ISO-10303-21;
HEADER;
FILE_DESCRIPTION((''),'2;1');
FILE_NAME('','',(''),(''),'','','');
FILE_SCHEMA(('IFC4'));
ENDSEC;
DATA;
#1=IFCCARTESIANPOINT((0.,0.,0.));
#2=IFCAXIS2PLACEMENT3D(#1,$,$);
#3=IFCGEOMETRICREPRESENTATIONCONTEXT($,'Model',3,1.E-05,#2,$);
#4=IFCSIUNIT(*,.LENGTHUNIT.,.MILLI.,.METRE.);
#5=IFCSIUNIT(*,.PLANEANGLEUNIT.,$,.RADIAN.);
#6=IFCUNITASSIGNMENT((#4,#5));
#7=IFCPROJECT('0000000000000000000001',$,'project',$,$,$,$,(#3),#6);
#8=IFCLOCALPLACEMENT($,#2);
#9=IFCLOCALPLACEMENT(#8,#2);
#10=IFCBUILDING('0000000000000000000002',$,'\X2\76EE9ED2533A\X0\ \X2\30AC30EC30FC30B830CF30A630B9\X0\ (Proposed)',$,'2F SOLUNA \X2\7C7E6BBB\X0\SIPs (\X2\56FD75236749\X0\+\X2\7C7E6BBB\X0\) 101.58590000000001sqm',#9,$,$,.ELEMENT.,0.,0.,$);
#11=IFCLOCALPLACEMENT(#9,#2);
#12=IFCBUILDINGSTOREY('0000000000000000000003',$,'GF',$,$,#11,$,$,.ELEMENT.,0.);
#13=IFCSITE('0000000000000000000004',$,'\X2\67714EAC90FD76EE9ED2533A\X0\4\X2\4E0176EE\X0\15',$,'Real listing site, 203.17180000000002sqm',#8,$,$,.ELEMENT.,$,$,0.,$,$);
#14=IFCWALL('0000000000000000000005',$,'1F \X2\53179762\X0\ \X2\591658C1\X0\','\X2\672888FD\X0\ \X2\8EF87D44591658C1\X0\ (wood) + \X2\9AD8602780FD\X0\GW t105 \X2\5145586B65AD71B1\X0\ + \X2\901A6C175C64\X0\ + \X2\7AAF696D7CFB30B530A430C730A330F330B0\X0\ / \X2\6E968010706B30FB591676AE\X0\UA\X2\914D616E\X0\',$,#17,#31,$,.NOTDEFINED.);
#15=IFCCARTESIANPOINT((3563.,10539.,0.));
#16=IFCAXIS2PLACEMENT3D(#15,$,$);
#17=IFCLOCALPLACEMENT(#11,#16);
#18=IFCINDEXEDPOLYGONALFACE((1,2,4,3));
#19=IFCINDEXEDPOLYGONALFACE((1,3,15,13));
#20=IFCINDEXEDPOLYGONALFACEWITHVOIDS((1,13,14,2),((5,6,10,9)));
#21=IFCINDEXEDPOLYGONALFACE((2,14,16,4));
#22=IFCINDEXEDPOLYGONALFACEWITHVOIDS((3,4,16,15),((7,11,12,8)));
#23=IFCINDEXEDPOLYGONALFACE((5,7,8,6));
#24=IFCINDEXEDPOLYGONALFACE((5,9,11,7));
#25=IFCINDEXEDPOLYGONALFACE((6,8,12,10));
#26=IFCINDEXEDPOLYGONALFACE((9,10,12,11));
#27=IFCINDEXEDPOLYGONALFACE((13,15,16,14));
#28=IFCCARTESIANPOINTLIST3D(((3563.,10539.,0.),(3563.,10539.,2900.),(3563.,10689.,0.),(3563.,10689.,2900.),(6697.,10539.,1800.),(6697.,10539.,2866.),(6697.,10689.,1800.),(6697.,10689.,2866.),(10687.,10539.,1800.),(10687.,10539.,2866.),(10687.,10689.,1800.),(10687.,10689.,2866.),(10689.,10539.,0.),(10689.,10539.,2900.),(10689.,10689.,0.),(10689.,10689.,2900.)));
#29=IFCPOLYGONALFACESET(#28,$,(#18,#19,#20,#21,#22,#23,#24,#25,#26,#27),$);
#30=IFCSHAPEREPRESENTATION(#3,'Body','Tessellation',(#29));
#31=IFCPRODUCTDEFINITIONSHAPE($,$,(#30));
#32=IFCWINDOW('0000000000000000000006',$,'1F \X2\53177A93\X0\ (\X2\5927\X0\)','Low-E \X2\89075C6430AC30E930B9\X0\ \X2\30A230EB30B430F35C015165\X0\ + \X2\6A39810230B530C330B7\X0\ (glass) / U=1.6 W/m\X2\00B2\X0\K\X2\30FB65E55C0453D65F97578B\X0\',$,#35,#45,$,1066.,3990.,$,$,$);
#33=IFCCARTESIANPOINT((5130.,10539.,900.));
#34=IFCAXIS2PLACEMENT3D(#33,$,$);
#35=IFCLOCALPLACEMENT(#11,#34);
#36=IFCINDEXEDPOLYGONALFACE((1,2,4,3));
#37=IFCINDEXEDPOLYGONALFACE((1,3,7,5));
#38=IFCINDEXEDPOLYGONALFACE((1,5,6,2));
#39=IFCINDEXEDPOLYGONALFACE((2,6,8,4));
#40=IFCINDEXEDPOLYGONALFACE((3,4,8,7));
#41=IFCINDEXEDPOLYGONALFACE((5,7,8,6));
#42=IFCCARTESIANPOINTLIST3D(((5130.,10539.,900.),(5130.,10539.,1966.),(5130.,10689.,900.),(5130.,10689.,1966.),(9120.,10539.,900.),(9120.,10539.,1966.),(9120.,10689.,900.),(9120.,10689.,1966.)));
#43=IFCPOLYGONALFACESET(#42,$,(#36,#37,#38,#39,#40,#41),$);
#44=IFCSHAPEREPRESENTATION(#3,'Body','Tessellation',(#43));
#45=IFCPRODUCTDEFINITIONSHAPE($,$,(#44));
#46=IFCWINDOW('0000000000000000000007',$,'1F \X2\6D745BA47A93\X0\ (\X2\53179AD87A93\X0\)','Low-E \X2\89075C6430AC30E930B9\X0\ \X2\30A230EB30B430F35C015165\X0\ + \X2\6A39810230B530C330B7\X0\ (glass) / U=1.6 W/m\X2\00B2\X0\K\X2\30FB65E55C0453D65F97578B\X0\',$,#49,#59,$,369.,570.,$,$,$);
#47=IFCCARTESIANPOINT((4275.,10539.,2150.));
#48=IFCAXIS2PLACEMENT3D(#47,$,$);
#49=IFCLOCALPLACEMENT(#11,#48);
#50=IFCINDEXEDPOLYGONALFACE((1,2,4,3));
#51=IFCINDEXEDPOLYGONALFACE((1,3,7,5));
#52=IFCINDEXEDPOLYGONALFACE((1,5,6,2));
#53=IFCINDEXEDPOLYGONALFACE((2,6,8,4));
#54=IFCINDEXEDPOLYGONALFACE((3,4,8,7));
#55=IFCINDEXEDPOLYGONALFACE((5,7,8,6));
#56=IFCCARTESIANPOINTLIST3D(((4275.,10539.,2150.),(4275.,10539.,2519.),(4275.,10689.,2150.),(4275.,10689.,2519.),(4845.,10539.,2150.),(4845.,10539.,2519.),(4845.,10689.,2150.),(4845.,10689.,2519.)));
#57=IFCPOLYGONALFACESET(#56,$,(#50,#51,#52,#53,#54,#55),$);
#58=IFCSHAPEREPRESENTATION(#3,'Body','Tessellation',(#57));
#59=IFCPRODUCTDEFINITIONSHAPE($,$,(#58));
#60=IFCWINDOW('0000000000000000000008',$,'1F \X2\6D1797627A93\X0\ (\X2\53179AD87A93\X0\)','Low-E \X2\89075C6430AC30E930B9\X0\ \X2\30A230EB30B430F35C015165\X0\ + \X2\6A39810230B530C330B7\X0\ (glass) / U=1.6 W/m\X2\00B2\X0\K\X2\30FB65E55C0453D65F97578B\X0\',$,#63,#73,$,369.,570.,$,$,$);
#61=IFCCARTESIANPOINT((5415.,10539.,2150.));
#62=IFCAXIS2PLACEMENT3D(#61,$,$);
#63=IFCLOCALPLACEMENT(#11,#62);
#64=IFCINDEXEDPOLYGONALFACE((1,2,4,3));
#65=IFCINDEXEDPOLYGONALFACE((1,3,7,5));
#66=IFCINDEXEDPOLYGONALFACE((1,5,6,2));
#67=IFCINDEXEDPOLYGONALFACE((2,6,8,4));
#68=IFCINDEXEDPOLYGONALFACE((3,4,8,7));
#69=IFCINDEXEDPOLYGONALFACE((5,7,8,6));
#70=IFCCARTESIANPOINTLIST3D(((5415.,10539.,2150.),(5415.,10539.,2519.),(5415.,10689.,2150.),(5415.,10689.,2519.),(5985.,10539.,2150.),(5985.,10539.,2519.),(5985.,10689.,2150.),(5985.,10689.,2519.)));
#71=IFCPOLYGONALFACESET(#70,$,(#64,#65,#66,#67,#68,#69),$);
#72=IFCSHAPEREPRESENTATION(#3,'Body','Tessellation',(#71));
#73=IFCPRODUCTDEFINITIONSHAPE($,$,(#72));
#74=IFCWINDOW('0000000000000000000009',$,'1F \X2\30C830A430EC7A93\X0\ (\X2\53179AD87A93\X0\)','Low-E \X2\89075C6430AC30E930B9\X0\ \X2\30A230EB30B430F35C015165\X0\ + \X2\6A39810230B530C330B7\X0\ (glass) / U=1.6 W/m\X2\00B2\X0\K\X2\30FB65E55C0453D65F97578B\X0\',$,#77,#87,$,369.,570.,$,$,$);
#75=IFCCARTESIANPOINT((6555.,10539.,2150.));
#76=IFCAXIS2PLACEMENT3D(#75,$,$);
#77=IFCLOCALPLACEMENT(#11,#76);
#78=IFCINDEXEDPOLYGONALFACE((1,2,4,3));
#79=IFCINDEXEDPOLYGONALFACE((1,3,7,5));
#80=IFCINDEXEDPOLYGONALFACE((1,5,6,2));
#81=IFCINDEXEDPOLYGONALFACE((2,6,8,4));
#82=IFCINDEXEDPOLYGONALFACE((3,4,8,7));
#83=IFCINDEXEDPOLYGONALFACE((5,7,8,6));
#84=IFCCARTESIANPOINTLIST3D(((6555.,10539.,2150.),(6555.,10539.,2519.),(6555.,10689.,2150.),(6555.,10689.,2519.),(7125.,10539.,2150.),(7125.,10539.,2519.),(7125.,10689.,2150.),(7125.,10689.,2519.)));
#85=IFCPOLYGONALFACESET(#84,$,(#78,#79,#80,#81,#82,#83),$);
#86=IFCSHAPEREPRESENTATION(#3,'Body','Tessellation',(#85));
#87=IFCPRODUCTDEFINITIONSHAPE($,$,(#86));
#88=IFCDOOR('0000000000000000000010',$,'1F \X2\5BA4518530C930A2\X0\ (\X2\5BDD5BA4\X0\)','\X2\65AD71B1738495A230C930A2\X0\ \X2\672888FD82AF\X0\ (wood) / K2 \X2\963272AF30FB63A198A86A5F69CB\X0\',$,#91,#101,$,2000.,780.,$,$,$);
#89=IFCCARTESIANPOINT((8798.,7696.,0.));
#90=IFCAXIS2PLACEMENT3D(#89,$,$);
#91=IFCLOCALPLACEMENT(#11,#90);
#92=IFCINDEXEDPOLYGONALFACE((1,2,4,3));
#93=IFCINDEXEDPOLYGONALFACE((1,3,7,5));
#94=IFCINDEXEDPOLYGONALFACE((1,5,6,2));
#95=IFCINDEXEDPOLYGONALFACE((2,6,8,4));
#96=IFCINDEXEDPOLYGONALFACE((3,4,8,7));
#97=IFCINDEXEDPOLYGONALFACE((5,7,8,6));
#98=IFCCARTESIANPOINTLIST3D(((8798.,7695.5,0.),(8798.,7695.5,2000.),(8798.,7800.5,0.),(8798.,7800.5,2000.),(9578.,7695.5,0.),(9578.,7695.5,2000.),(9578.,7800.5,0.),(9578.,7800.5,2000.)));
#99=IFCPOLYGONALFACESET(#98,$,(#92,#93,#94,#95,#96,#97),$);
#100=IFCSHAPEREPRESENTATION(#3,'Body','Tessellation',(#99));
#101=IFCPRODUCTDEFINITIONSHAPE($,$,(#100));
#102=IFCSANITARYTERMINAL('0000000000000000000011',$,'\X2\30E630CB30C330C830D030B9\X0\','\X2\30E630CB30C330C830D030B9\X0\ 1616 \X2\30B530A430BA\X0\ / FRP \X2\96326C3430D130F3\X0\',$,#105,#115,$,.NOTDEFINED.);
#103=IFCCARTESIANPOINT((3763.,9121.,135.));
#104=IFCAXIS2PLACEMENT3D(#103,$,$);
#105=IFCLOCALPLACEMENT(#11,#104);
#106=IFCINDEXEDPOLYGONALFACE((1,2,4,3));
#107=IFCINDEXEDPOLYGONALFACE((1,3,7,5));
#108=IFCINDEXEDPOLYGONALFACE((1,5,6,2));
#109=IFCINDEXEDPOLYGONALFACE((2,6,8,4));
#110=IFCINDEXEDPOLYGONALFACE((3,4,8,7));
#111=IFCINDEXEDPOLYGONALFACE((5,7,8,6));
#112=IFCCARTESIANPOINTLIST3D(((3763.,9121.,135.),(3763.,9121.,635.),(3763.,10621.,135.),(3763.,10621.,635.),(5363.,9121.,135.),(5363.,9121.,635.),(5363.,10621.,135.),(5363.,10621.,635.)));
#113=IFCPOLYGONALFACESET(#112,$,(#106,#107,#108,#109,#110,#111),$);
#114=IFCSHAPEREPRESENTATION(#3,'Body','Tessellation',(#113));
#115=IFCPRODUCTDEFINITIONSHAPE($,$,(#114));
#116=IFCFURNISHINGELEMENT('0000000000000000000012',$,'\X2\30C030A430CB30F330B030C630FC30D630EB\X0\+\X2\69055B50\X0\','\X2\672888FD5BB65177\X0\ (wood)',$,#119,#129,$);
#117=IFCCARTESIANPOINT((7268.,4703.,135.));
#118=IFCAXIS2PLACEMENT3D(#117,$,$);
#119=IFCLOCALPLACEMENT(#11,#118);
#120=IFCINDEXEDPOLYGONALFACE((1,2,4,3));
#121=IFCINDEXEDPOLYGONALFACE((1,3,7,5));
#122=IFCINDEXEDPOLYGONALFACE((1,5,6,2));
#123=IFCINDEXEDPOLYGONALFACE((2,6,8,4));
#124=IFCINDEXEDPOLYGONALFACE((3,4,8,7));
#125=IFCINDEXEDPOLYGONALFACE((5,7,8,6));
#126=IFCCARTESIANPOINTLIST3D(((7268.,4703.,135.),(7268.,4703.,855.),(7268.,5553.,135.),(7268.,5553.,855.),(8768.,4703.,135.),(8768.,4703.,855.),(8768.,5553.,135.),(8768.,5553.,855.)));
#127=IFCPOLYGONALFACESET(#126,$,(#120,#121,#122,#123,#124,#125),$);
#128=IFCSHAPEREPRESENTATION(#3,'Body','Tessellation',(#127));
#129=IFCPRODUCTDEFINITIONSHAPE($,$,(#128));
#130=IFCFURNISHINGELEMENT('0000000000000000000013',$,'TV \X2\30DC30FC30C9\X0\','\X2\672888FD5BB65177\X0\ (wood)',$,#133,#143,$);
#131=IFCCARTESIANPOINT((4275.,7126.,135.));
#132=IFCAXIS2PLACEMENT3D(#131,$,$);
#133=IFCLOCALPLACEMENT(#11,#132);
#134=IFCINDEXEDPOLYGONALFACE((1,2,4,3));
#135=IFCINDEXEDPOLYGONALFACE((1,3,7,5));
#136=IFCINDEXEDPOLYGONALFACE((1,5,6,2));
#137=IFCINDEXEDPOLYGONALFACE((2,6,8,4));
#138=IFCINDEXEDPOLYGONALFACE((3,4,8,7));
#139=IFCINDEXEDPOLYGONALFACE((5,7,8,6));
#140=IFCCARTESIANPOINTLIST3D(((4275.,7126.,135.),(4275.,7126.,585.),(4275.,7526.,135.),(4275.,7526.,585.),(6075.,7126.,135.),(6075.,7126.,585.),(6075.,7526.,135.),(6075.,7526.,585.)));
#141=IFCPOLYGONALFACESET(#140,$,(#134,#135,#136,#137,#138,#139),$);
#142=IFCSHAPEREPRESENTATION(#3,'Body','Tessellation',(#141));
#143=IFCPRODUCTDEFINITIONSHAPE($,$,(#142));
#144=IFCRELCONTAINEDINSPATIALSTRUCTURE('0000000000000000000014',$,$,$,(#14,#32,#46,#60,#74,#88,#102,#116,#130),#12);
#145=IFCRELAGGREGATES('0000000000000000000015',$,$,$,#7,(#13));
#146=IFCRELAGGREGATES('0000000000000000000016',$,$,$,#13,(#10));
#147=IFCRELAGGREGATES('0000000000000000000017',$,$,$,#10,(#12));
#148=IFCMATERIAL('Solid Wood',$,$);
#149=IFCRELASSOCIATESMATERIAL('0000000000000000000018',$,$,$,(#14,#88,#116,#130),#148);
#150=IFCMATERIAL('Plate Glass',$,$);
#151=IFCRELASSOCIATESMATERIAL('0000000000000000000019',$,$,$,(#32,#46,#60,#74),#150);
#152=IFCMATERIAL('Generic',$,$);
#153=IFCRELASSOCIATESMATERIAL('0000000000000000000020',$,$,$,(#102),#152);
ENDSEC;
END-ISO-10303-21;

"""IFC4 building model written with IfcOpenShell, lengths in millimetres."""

from ifc_helpers import new_model, si_unit, frame, frame_2d, origin, place, context, project, spatial, rectangle, extrude, material, element, fill, save


model = new_model("IFC4")

# Units and contexts
model_context = context("Model", 3, precision=1e-05, world=origin())
ifc_project = project(units=[si_unit("LENGTHUNIT", "METRE", prefix="MILLI"), si_unit("PLANEANGLEUNIT", "RADIAN")], contexts=[model_context])

# Site, building, storey
site_placement = place(None, origin())
site = spatial("IfcSite", under=ifc_project, at=site_placement, Name="東京都目黒区4丁目15", ObjectType="Real listing site, 203.17180000000002sqm", CompositionType="ELEMENT", RefElevation=0.0)
building_placement = place(site_placement, origin())
building = spatial("IfcBuilding", under=site, at=building_placement, Name="目黒区 ガレージハウス (Proposed)", ObjectType="2F SOLUNA 籾殻SIPs (国産杉+籾殻) 101.58590000000001sqm", CompositionType="ELEMENT", ElevationOfRefHeight=0.0, ElevationOfTerrain=0.0)
storey_placement = place(building_placement, origin())
storey = spatial("IfcBuildingStorey", under=building, at=storey_placement, Name="GF", CompositionType="ELEMENT", Elevation=0.0)

# Wall, openings, windows
ifc_material_1 = material(Name="Solid Wood")
wall_1_placement = place(storey_placement, frame((3563.0, 10539.0, 0.0)))
wall_1 = element("IfcWall", 1, at=wall_1_placement, inside=storey, material=ifc_material_1, Name="1F 北面 外壁", Description="木製 軸組外壁 (wood) + 高性能GW t105 充填断熱 + 通気層 + 窯業系サイディング / 準耐火・外皮UA配慮", PredefinedType="NOTDEFINED", context=model_context, shape_type="SweptSolid", body=[
    extrude(rectangle(XDim=7126.0, YDim=150.0, at=frame_2d((3563.0, 75.0))), frame((3563.0, 10539.0, 0.0)), (0.0, 0.0, 1.0), 2900.0),
])
opening_1_placement = place(storey_placement, frame((5130.0, 10539.0, 900.0)))
opening_1 = element("IfcOpeningElement", 2, at=opening_1_placement, cuts=wall_1, PredefinedType="NOTDEFINED", context=model_context, shape_type="SweptSolid", body=[
    extrude(rectangle(XDim=3990.0, YDim=150.0, at=frame_2d((1995.0, 75.0))), frame((5130.0, 10539.0, 900.0)), (0.0, 0.0, 1.0), 1066.0),
])
opening_2_placement = place(storey_placement, frame((4275.0, 10539.0, 2150.0)))
opening_2 = element("IfcOpeningElement", 3, at=opening_2_placement, cuts=wall_1, PredefinedType="NOTDEFINED", context=model_context, shape_type="SweptSolid", body=[
    extrude(rectangle(XDim=570.0, YDim=150.0, at=frame_2d((285.0, 75.0))), frame((4275.0, 10539.0, 2150.0)), (0.0, 0.0, 1.0), 369.0),
])
opening_3_placement = place(storey_placement, frame((5415.0, 10539.0, 2150.0)))
opening_3 = element("IfcOpeningElement", 4, at=opening_3_placement, cuts=wall_1, PredefinedType="NOTDEFINED", context=model_context, shape_type="SweptSolid", body=[
    extrude(rectangle(XDim=570.0, YDim=150.0, at=frame_2d((285.0, 75.0))), frame((5415.0, 10539.0, 2150.0)), (0.0, 0.0, 1.0), 369.0),
])
opening_4_placement = place(storey_placement, frame((6555.0, 10539.0, 2150.0)))
opening_4 = element("IfcOpeningElement", 5, at=opening_4_placement, cuts=wall_1, PredefinedType="NOTDEFINED", context=model_context, shape_type="SweptSolid", body=[
    extrude(rectangle(XDim=570.0, YDim=150.0, at=frame_2d((285.0, 75.0))), frame((6555.0, 10539.0, 2150.0)), (0.0, 0.0, 1.0), 369.0),
])
ifc_material_2 = material(Name="Plate Glass")
window_1_placement = place(storey_placement, frame((5130.0, 10539.0, 900.0)))
window_1 = element("IfcWindow", 6, at=window_1_placement, inside=storey, material=ifc_material_2, Name="1F 北窓 (大)", Description="Low-E 複層ガラス アルゴン封入 + 樹脂サッシ (glass) / U=1.6 W/m²K・日射取得型", OverallHeight=1066.0, OverallWidth=3990.0, context=model_context, shape_type="SweptSolid", body=[
    extrude(rectangle(XDim=3990.0, YDim=150.0, at=frame_2d((1995.0, 75.0))), frame((5130.0, 10539.0, 900.0)), (0.0, 0.0, 1.0), 1066.0),
])
fill(opening_1, window_1)
window_2_placement = place(storey_placement, frame((4275.0, 10539.0, 2150.0)))
window_2 = element("IfcWindow", 7, at=window_2_placement, inside=storey, material=ifc_material_2, Name="1F 浴室窓 (北高窓)", Description="Low-E 複層ガラス アルゴン封入 + 樹脂サッシ (glass) / U=1.6 W/m²K・日射取得型", OverallHeight=369.0, OverallWidth=570.0, context=model_context, shape_type="SweptSolid", body=[
    extrude(rectangle(XDim=570.0, YDim=150.0, at=frame_2d((285.0, 75.0))), frame((4275.0, 10539.0, 2150.0)), (0.0, 0.0, 1.0), 369.0),
])
fill(opening_2, window_2)
window_3_placement = place(storey_placement, frame((5415.0, 10539.0, 2150.0)))
window_3 = element("IfcWindow", 8, at=window_3_placement, inside=storey, material=ifc_material_2, Name="1F 洗面窓 (北高窓)", Description="Low-E 複層ガラス アルゴン封入 + 樹脂サッシ (glass) / U=1.6 W/m²K・日射取得型", OverallHeight=369.0, OverallWidth=570.0, context=model_context, shape_type="SweptSolid", body=[
    extrude(rectangle(XDim=570.0, YDim=150.0, at=frame_2d((285.0, 75.0))), frame((5415.0, 10539.0, 2150.0)), (0.0, 0.0, 1.0), 369.0),
])
fill(opening_3, window_3)
window_4_placement = place(storey_placement, frame((6555.0, 10539.0, 2150.0)))
window_4 = element("IfcWindow", 9, at=window_4_placement, inside=storey, material=ifc_material_2, Name="1F トイレ窓 (北高窓)", Description="Low-E 複層ガラス アルゴン封入 + 樹脂サッシ (glass) / U=1.6 W/m²K・日射取得型", OverallHeight=369.0, OverallWidth=570.0, context=model_context, shape_type="SweptSolid", body=[
    extrude(rectangle(XDim=570.0, YDim=150.0, at=frame_2d((285.0, 75.0))), frame((6555.0, 10539.0, 2150.0)), (0.0, 0.0, 1.0), 369.0),
])
fill(opening_4, window_4)

# Door
door_1_placement = place(storey_placement, frame((8798.0, 7696.0, 0.0)))
element("IfcDoor", 10, at=door_1_placement, inside=storey, material=ifc_material_1, Name="1F 室内ドア (寝室)", Description="断熱玄関ドア 木製芯 (wood) / K2 防犯・採風機構", OverallHeight=2000.0, OverallWidth=780.0, context=model_context, shape_type="SweptSolid", body=[
    extrude(rectangle(XDim=780.0, YDim=105.0, at=frame_2d((390.0, 52.0))), frame((8798.0, 7696.0, 0.0)), (0.0, 0.0, 1.0), 2000.0),
])

# Sanitary terminal
ifc_material_3 = material(Name="Generic")
sanitary_terminal_placement = place(storey_placement, frame((3763.0, 9121.0, 135.0)))
element("IfcSanitaryTerminal", 11, at=sanitary_terminal_placement, inside=storey, material=ifc_material_3, Name="ユニットバス", Description="ユニットバス 1616 サイズ / FRP 防水パン", PredefinedType="NOTDEFINED", context=model_context, shape_type="SweptSolid", body=[
    extrude(rectangle(XDim=1600.0, YDim=1500.0, at=frame_2d((800.0, 750.0))), frame((3763.0, 9121.0, 135.0)), (0.0, 0.0, 1.0), 500.0),
])

# Furnishing elements
furnishing_1_placement = place(storey_placement, frame((7268.0, 4703.0, 135.0)))
element("IfcFurnishingElement", 12, at=furnishing_1_placement, inside=storey, material=ifc_material_1, Name="ダイニングテーブル+椅子", Description="木製家具 (wood)", context=model_context, shape_type="SweptSolid", body=[
    extrude(rectangle(XDim=1500.0, YDim=850.0, at=frame_2d((750.0, 425.0))), frame((7268.0, 4703.0, 135.0)), (0.0, 0.0, 1.0), 720.0),
])
furnishing_2_placement = place(storey_placement, frame((4275.0, 7126.0, 135.0)))
element("IfcFurnishingElement", 13, at=furnishing_2_placement, inside=storey, material=ifc_material_1, Name="TV ボード", Description="木製家具 (wood)", context=model_context, shape_type="SweptSolid", body=[
    extrude(rectangle(XDim=1800.0, YDim=400.0, at=frame_2d((900.0, 200.0))), frame((4275.0, 7126.0, 135.0)), (0.0, 0.0, 1.0), 450.0),
])

save(model, "model.ifc")
